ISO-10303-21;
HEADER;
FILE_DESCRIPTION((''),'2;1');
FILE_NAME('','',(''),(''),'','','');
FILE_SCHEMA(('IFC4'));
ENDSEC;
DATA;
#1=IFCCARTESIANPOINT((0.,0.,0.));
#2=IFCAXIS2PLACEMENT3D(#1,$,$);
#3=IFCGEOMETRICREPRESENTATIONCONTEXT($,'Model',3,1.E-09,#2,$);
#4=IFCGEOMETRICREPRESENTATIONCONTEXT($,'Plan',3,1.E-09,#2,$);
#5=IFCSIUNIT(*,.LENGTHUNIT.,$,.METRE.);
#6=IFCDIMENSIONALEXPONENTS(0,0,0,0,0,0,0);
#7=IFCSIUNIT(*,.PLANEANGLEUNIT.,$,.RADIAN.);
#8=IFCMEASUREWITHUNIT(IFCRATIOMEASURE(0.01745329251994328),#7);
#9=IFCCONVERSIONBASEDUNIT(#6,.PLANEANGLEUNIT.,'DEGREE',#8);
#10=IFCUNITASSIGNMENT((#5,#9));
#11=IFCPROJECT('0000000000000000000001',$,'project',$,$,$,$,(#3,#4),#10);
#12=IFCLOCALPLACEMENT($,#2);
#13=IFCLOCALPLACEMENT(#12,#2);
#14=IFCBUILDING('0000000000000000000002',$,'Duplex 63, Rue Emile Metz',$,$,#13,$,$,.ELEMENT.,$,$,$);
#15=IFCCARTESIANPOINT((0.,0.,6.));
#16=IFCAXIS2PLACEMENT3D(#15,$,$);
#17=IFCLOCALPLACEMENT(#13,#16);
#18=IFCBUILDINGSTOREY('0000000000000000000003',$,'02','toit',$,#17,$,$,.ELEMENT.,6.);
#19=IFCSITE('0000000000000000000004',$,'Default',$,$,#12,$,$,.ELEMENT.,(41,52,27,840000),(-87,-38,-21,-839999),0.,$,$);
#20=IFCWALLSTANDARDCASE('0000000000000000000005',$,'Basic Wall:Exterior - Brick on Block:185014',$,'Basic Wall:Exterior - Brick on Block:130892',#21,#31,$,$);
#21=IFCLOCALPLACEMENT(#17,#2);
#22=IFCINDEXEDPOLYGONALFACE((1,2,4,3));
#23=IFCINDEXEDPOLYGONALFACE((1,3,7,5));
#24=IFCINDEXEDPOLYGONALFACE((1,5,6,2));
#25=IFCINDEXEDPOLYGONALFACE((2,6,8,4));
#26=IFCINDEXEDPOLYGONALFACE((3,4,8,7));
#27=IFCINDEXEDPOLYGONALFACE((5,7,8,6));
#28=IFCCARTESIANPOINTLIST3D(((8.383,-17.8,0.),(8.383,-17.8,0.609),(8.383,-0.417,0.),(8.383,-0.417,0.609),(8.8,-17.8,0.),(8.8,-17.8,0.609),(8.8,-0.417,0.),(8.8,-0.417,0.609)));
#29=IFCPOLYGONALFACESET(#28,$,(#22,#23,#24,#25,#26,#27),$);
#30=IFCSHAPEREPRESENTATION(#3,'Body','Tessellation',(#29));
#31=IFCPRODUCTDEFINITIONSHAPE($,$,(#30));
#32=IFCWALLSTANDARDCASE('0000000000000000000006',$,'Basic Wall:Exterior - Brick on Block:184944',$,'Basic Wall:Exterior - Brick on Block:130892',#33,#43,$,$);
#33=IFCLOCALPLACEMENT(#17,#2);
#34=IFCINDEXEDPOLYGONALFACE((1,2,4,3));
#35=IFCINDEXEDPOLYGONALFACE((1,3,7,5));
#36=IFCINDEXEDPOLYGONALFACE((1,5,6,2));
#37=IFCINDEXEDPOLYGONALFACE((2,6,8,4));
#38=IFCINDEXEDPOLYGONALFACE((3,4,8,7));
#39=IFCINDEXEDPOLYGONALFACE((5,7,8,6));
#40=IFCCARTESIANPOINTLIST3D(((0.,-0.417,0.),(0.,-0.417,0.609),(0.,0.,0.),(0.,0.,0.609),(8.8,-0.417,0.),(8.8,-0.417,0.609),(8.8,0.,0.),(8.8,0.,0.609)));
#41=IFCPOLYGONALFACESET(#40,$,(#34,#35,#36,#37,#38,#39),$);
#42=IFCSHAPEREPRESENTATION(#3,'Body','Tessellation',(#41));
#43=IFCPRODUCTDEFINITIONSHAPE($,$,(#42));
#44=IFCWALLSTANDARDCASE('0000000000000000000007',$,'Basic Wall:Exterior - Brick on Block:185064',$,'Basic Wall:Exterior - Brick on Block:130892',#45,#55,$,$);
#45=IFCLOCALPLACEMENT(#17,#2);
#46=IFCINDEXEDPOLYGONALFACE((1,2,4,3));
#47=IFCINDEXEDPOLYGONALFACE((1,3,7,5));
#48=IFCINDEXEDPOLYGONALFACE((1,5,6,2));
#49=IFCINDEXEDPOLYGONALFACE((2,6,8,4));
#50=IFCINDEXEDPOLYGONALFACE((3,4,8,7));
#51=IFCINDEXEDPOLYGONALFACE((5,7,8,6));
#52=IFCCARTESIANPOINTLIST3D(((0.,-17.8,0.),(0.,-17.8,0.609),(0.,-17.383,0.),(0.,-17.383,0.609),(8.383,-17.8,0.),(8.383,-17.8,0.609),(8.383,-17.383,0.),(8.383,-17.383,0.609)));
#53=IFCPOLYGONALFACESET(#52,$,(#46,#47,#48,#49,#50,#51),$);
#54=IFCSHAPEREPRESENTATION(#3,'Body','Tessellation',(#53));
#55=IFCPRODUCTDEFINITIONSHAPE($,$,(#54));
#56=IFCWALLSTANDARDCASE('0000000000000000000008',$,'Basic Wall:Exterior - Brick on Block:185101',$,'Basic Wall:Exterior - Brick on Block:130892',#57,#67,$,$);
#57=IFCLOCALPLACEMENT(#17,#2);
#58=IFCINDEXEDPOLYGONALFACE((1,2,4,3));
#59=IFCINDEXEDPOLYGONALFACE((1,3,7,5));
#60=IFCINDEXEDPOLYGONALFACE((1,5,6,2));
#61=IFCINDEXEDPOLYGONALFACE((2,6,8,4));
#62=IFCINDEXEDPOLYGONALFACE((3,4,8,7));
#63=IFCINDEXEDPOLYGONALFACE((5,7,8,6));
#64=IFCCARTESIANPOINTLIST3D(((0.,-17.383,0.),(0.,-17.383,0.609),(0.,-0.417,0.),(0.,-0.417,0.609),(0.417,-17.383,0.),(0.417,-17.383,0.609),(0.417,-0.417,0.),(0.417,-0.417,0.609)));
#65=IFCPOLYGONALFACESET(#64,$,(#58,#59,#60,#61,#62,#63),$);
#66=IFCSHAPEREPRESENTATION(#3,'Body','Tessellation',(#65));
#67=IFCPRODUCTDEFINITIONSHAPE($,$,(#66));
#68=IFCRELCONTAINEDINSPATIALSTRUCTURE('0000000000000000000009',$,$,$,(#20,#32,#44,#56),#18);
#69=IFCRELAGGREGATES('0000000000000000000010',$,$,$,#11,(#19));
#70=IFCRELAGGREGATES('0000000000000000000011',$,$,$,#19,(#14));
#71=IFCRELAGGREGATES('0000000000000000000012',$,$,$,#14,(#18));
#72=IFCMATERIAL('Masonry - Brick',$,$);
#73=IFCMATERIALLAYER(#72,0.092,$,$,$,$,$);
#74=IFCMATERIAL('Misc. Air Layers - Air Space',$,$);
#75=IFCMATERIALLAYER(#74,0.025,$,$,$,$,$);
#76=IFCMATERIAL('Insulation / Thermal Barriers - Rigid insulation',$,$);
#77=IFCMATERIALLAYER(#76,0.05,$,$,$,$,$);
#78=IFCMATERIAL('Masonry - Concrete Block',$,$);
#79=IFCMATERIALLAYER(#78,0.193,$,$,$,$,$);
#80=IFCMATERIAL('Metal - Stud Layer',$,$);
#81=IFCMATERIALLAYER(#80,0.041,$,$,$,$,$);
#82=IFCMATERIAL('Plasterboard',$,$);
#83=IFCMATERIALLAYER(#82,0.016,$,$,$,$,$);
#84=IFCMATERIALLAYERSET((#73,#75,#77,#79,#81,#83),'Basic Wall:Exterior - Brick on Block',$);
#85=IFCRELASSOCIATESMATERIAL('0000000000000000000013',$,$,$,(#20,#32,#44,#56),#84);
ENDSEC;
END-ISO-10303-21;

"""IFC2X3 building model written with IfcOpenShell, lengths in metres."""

from ifc_helpers import new_model, entity, si_unit, converted_unit, frame, frame_2d, origin, place, context, project, spatial, rectangle, extrude, material, layer, layer_set, layer_usage, element, save


model = new_model("IFC2X3")

# Units and contexts
model_context = context("Model", 3, precision=1e-09, world=origin())
plan_context = context("Plan", 3, precision=1e-09, world=origin())
ifc_project = project(units=[si_unit("LENGTHUNIT", "METRE"), converted_unit("PLANEANGLEUNIT", "DEGREE", entity("IfcRatioMeasure", 0.01745329251994328), si_unit("PLANEANGLEUNIT", "RADIAN"), dimensions=[0, 0, 0, 0, 0, 0, 0])], contexts=[model_context, plan_context])

# Site, building, storey
site_placement = place(None, origin())
site = spatial("IfcSite", under=ifc_project, at=site_placement, Name="Default", CompositionType="ELEMENT", RefLatitude=(41, 52, 27, 840000), RefLongitude=(-87, -38, -21, -839999), RefElevation=0.0)
building_placement = place(site_placement, origin())
building = spatial("IfcBuilding", under=site, at=building_placement, Name="Duplex 63, Rue Emile Metz", CompositionType="ELEMENT")
storey_placement = place(building_placement, frame((0.0, 0.0, 6.0)))
storey = spatial("IfcBuildingStorey", under=building, at=storey_placement, Name="02", Description="toit", CompositionType="ELEMENT", Elevation=6.0)

# Walls
ifc_material_1 = material(Name="Masonry - Brick")
ifc_layer_1 = layer(ifc_material_1, 0.092)
ifc_material_2 = material(Name="Misc. Air Layers - Air Space")
ifc_layer_2 = layer(ifc_material_2, 0.025)
ifc_material_3 = material(Name="Insulation / Thermal Barriers - Rigid insulation")
ifc_layer_3 = layer(ifc_material_3, 0.05)
ifc_material_4 = material(Name="Masonry - Concrete Block")
ifc_layer_4 = layer(ifc_material_4, 0.193)
ifc_material_5 = material(Name="Metal - Stud Layer")
ifc_layer_5 = layer(ifc_material_5, 0.041)
ifc_material_6 = material(Name="Plasterboard")
ifc_layer_6 = layer(ifc_material_6, 0.016)
ifc_layer_set = layer_set([ifc_layer_1, ifc_layer_2, ifc_layer_3, ifc_layer_4, ifc_layer_5, ifc_layer_6], Name="Basic Wall:Exterior - Brick on Block")
ifc_layer_usage = layer_usage(ifc_layer_set, "AXIS2", "NEGATIVE", 0.2085)
wall_1_placement = place(storey_placement, frame((8.5915, -0.417, 0.0), z_axis=(0.0, 0.0, 1.0), x_axis=(0.0, -1.0, 0.0)))
element("IfcWallStandardCase", 1, at=wall_1_placement, inside=storey, material=ifc_layer_usage, Name="Basic Wall:Exterior - Brick on Block:185014", ObjectType="Basic Wall:Exterior - Brick on Block:130892", context=model_context, shape_type="SweptSolid", body=[
    extrude(rectangle(XDim=17.383, YDim=0.417, at=frame_2d((8.6915, 0.0), x_axis=(-1.0, 0.0))), origin(), (0.0, 0.0, 1.0), 0.609),
])
wall_2_placement = place(storey_placement, frame((0.0, -0.2085, 0.0)))
element("IfcWallStandardCase", 2, at=wall_2_placement, inside=storey, material=ifc_layer_usage, Name="Basic Wall:Exterior - Brick on Block:184944", ObjectType="Basic Wall:Exterior - Brick on Block:130892", context=model_context, shape_type="SweptSolid", body=[
    extrude(rectangle(XDim=8.8, YDim=0.417, at=frame_2d((4.4, 0.0), x_axis=(-1.0, 0.0))), origin(), (0.0, 0.0, 1.0), 0.609),
])
wall_3_placement = place(storey_placement, frame((8.383, -17.5915, 0.0), z_axis=(0.0, 0.0, 1.0), x_axis=(-1.0, 0.0, 0.0)))
element("IfcWallStandardCase", 3, at=wall_3_placement, inside=storey, material=ifc_layer_usage, Name="Basic Wall:Exterior - Brick on Block:185064", ObjectType="Basic Wall:Exterior - Brick on Block:130892", context=model_context, shape_type="SweptSolid", body=[
    extrude(rectangle(XDim=8.383, YDim=0.417, at=frame_2d((4.1915, 0.0), x_axis=(-1.0, 0.0))), origin(), (0.0, 0.0, 1.0), 0.609),
])
wall_4_placement = place(storey_placement, frame((0.2085, -17.383, 0.0), z_axis=(0.0, 0.0, 1.0), x_axis=(0.0, 1.0, 0.0)))
element("IfcWallStandardCase", 4, at=wall_4_placement, inside=storey, material=ifc_layer_usage, Name="Basic Wall:Exterior - Brick on Block:185101", ObjectType="Basic Wall:Exterior - Brick on Block:130892", context=model_context, shape_type="SweptSolid", body=[
    extrude(rectangle(XDim=16.966, YDim=0.417, at=frame_2d((8.483, 0.0), x_axis=(-1.0, 0.0))), origin(), (0.0, 0.0, 1.0), 0.609),
])

save(model, "model.ifc")
